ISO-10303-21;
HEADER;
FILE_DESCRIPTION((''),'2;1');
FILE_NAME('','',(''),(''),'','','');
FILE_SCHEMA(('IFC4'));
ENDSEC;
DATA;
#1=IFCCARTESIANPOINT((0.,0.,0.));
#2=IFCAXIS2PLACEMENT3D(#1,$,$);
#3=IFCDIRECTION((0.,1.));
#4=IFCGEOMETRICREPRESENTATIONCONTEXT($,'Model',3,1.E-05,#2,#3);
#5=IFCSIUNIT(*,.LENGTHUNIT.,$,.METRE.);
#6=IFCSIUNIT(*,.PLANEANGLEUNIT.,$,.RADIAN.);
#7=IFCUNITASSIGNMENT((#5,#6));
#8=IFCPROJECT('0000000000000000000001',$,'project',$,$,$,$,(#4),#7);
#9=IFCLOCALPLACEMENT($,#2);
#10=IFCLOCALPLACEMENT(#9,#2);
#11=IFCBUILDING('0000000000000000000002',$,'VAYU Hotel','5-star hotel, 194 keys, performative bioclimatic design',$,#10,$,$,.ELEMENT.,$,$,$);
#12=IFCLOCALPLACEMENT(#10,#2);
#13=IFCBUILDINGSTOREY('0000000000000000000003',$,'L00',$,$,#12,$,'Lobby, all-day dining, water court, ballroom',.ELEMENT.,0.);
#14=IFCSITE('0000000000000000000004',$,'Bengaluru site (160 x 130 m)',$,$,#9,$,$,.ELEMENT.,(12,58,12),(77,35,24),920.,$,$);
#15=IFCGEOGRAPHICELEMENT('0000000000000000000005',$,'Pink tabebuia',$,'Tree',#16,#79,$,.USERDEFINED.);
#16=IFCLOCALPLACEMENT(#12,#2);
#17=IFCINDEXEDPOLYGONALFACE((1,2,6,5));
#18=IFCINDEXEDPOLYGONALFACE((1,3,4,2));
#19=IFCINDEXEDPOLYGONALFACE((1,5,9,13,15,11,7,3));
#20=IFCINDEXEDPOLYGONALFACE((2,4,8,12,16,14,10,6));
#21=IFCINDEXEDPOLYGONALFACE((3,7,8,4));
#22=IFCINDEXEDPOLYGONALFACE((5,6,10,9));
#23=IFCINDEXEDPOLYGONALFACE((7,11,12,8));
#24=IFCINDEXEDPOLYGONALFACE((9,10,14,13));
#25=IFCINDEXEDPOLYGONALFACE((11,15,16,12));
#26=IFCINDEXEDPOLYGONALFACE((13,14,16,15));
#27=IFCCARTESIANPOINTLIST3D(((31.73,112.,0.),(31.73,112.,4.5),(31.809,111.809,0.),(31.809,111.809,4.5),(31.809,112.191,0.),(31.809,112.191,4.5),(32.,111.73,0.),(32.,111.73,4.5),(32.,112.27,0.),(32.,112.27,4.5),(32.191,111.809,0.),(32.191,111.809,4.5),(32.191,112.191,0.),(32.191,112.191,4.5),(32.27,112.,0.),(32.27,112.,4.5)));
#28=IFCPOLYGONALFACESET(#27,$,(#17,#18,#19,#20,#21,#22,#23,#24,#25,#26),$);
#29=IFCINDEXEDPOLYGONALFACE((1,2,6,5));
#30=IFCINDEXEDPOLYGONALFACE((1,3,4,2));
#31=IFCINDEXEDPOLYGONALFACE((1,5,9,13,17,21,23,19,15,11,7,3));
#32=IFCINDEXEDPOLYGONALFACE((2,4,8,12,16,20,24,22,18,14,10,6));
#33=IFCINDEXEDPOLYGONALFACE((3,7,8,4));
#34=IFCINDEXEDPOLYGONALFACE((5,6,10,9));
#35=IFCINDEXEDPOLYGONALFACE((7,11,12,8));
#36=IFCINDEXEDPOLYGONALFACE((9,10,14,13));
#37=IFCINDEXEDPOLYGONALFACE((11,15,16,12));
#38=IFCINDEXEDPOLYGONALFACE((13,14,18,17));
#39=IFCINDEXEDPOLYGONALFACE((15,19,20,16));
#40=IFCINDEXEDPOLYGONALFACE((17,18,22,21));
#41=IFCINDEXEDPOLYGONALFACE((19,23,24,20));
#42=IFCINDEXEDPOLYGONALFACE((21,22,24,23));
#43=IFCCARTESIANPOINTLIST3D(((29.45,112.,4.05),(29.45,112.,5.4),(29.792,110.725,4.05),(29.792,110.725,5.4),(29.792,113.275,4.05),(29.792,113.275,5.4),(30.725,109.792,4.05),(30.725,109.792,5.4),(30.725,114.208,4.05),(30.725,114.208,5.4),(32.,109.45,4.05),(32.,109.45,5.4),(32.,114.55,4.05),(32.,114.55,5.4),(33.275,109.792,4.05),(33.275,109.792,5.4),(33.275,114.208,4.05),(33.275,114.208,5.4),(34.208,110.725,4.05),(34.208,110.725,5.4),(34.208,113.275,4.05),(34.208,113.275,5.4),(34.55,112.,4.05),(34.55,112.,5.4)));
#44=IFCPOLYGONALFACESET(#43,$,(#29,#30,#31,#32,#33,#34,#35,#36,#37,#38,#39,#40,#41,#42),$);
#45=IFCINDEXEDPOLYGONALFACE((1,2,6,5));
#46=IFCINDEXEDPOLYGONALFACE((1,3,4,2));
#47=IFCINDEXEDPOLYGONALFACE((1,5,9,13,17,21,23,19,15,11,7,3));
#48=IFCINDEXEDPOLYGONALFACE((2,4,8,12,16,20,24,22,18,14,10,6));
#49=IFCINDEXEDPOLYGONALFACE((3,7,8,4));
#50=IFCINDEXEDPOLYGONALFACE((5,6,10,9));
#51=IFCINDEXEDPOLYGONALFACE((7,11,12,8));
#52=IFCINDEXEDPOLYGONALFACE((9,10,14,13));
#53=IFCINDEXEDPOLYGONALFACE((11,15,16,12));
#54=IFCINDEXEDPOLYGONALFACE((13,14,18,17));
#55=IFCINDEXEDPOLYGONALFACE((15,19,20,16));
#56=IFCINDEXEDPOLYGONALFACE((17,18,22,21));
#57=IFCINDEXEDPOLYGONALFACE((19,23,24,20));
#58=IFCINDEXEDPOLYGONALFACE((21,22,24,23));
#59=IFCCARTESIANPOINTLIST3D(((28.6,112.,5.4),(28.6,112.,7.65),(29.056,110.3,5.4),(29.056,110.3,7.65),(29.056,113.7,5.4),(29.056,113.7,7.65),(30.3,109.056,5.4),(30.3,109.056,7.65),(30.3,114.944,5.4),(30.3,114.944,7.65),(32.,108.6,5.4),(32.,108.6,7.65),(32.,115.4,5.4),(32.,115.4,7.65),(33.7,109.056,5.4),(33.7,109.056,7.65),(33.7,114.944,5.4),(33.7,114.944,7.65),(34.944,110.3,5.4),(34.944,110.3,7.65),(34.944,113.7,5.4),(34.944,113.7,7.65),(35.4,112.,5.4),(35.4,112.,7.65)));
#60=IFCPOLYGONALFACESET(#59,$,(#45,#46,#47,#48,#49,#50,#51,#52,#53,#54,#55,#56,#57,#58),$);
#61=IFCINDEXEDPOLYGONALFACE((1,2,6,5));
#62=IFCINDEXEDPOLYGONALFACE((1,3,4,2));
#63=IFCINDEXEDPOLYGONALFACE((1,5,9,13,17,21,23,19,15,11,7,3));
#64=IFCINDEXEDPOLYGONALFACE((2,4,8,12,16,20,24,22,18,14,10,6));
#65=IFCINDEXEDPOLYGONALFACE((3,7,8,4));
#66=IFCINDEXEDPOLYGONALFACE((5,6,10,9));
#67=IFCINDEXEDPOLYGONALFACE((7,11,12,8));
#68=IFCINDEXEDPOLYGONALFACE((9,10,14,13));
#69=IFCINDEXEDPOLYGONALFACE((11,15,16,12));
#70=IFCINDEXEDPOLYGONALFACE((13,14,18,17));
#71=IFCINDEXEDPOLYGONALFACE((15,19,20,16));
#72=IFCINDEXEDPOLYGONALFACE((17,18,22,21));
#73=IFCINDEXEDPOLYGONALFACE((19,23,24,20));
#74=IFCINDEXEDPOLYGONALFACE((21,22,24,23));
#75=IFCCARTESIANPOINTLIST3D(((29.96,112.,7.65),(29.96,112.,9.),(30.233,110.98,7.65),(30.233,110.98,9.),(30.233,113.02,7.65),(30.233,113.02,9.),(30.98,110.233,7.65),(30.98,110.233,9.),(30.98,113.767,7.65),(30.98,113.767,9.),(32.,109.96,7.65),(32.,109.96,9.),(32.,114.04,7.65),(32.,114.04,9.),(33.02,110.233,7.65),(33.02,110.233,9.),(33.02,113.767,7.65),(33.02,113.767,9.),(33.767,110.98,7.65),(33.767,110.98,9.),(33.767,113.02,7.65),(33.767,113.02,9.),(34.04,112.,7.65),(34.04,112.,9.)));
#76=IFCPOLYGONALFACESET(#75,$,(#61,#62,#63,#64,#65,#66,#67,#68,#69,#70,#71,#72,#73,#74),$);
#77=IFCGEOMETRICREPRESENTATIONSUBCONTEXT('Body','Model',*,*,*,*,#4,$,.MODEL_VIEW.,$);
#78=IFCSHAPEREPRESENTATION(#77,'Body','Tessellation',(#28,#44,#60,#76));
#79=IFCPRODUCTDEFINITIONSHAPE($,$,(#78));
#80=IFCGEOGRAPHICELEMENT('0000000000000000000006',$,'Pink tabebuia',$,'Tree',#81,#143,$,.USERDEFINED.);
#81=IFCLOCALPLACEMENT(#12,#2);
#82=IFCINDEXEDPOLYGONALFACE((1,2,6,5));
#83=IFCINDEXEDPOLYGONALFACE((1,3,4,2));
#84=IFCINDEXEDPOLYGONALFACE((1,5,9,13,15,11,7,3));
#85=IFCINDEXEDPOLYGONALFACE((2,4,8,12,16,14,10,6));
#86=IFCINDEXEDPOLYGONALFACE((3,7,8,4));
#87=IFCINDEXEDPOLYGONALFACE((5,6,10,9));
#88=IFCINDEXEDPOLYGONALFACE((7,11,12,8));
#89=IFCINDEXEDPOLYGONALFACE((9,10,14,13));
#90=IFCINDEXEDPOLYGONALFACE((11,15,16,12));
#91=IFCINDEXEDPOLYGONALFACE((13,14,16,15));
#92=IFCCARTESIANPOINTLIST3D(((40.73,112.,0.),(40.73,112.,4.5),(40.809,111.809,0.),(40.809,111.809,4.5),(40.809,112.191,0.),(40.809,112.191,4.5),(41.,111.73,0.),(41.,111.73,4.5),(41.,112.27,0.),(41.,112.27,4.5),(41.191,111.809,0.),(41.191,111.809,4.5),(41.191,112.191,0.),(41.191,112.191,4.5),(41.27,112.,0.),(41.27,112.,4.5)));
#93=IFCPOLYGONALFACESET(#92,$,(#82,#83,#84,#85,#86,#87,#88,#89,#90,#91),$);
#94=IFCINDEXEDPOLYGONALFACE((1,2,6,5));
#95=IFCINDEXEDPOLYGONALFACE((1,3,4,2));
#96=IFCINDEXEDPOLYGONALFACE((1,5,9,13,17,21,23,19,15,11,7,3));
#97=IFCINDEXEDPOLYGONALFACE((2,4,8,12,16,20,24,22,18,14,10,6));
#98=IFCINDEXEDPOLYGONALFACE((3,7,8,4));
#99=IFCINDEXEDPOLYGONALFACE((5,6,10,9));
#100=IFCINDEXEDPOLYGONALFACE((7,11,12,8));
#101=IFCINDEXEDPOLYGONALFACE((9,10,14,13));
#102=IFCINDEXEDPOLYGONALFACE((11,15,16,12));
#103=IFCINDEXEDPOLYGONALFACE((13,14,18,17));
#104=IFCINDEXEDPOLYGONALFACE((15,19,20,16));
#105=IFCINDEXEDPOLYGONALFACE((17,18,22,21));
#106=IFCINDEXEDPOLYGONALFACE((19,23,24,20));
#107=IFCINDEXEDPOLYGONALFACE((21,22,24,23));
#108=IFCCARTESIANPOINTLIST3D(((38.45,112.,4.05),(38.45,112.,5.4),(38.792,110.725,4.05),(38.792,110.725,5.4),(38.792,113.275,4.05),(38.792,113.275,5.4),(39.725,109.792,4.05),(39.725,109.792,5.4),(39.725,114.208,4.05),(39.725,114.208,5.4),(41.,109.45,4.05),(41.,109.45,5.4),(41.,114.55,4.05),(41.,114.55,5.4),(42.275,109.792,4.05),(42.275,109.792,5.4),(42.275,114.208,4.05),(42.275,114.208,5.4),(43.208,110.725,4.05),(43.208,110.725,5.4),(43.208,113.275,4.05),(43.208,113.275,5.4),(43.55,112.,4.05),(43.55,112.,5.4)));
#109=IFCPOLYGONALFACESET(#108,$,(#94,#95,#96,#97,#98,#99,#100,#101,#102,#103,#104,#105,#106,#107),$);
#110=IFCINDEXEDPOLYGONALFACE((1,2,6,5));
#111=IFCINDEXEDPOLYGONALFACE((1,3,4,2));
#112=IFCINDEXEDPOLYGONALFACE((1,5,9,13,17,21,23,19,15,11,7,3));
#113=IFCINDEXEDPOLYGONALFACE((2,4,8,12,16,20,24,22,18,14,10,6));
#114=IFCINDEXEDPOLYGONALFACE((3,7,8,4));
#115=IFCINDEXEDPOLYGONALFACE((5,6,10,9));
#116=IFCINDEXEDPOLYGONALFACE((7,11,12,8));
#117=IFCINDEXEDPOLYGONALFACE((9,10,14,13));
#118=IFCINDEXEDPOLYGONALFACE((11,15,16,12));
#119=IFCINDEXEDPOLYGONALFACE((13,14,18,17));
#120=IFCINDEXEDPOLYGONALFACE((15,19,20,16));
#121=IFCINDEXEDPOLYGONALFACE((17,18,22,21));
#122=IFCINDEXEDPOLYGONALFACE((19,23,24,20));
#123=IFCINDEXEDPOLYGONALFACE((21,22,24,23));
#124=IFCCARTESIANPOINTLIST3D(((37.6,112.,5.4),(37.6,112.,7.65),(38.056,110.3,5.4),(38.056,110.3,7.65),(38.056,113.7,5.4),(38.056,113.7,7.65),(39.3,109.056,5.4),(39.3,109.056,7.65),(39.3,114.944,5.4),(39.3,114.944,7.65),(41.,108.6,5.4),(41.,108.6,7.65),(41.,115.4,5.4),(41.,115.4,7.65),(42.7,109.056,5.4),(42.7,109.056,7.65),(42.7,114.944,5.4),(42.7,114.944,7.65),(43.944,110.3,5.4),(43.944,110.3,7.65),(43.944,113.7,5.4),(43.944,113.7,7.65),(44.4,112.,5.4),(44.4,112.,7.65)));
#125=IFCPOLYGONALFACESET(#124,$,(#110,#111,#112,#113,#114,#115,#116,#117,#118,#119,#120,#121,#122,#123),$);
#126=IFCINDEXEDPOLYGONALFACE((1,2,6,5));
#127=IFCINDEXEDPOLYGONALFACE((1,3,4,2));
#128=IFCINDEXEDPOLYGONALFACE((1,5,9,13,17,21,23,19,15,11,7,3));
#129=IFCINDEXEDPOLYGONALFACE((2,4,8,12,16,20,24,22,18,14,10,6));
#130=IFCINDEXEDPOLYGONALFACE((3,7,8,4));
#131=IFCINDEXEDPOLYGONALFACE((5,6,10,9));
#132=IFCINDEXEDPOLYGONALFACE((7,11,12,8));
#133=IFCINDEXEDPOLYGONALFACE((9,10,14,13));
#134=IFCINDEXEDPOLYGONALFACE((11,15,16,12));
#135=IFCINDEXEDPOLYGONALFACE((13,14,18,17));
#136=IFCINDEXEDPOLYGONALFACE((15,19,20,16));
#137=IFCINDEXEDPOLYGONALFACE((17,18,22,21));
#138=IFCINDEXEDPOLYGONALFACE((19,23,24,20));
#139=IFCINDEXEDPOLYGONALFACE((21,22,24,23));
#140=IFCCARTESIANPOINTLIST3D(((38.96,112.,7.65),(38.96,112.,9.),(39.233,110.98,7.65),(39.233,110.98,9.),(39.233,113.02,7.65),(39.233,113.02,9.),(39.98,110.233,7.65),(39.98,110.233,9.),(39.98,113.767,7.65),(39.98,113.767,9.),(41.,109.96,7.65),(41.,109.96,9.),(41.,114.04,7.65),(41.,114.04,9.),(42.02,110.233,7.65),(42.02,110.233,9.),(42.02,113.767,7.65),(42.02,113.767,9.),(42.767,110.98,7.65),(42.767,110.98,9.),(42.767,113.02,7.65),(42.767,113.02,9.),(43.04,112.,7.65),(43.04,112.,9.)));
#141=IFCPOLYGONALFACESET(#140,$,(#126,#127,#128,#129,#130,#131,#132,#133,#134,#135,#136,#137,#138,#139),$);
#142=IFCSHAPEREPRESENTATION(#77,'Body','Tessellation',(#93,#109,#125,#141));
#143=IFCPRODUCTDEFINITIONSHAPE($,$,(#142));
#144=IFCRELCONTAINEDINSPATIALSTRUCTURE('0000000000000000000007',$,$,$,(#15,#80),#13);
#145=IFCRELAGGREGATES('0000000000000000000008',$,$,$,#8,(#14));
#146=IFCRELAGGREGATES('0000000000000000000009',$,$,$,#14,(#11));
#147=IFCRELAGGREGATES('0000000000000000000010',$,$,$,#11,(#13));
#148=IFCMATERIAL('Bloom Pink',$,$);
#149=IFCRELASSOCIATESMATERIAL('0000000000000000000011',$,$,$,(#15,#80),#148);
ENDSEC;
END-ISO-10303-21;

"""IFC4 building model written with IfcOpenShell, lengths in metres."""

from ifc_helpers import new_model, si_unit, direction, frame, origin, place, context, subcontext, project, spatial, polyline, outline, extrude, material, element, save


model = new_model("IFC4")

# Units and contexts
model_context = context("Model", 3, precision=1e-05, world=origin(), true_north=direction((0.0, 1.0)))
body_context = subcontext(model_context, "Body", "Model", "MODEL_VIEW")
ifc_project = project(units=[si_unit("LENGTHUNIT", "METRE"), si_unit("PLANEANGLEUNIT", "RADIAN")], contexts=[model_context])

# Site, building, storey
site_placement = place(None, origin())
site = spatial("IfcSite", under=ifc_project, at=site_placement, Name="Bengaluru site (160 x 130 m)", CompositionType="ELEMENT", RefLatitude=(12, 58, 12), RefLongitude=(77, 35, 24), RefElevation=920.0)
building_placement = place(site_placement, origin())
building = spatial("IfcBuilding", under=site, at=building_placement, Name="VAYU Hotel", Description="5-star hotel, 194 keys, performative bioclimatic design", CompositionType="ELEMENT")
storey_placement = place(building_placement, origin())
storey = spatial("IfcBuildingStorey", under=building, at=storey_placement, Name="L00", LongName="Lobby, all-day dining, water court, ballroom", CompositionType="ELEMENT", Elevation=0.0)

# Geographic elements
ifc_material_1 = material(Name="Bloom Pink")
geographic_element_1_placement = place(storey_placement, origin())
element("IfcGeographicElement", 1, at=geographic_element_1_placement, inside=storey, material=ifc_material_1, Name="Pink tabebuia", ObjectType="Tree", PredefinedType="USERDEFINED", context=body_context, shape_type="SweptSolid", body=[
    extrude(outline(polyline([(32.27, 112.0), (32.191, 112.191), (32.0, 112.27), (31.809, 112.191), (31.73, 112.0), (31.809, 111.809), (32.0, 111.73), (32.191, 111.809), (32.27, 112.0)])), origin(), (0.0, 0.0, 1.0), 4.5),
    extrude(outline(polyline([(34.55, 112.0), (34.208, 113.275), (33.275, 114.208), (32.0, 114.55), (30.725, 114.208), (29.792, 113.275), (29.45, 112.0), (29.792, 110.725), (30.725, 109.792), (32.0, 109.45), (33.275, 109.792), (34.208, 110.725), (34.55, 112.0)])), frame((0.0, 0.0, 4.05)), (0.0, 0.0, 1.0), 1.35),
    extrude(outline(polyline([(35.4, 112.0), (34.944, 113.7), (33.7, 114.944), (32.0, 115.4), (30.3, 114.944), (29.056, 113.7), (28.6, 112.0), (29.056, 110.3), (30.3, 109.056), (32.0, 108.6), (33.7, 109.056), (34.944, 110.3), (35.4, 112.0)])), frame((0.0, 0.0, 5.4)), (0.0, 0.0, 1.0), 2.25),
    extrude(outline(polyline([(34.04, 112.0), (33.767, 113.02), (33.02, 113.767), (32.0, 114.04), (30.98, 113.767), (30.233, 113.02), (29.96, 112.0), (30.233, 110.98), (30.98, 110.233), (32.0, 109.96), (33.02, 110.233), (33.767, 110.98), (34.04, 112.0)])), frame((0.0, 0.0, 7.65)), (0.0, 0.0, 1.0), 1.35),
])
geographic_element_2_placement = place(storey_placement, origin())
element("IfcGeographicElement", 2, at=geographic_element_2_placement, inside=storey, material=ifc_material_1, Name="Pink tabebuia", ObjectType="Tree", PredefinedType="USERDEFINED", context=body_context, shape_type="SweptSolid", body=[
    extrude(outline(polyline([(41.27, 112.0), (41.191, 112.191), (41.0, 112.27), (40.809, 112.191), (40.73, 112.0), (40.809, 111.809), (41.0, 111.73), (41.191, 111.809), (41.27, 112.0)])), origin(), (0.0, 0.0, 1.0), 4.5),
    extrude(outline(polyline([(43.55, 112.0), (43.208, 113.275), (42.275, 114.208), (41.0, 114.55), (39.725, 114.208), (38.792, 113.275), (38.45, 112.0), (38.792, 110.725), (39.725, 109.792), (41.0, 109.45), (42.275, 109.792), (43.208, 110.725), (43.55, 112.0)])), frame((0.0, 0.0, 4.05)), (0.0, 0.0, 1.0), 1.35),
    extrude(outline(polyline([(44.4, 112.0), (43.944, 113.7), (42.7, 114.944), (41.0, 115.4), (39.3, 114.944), (38.056, 113.7), (37.6, 112.0), (38.056, 110.3), (39.3, 109.056), (41.0, 108.6), (42.7, 109.056), (43.944, 110.3), (44.4, 112.0)])), frame((0.0, 0.0, 5.4)), (0.0, 0.0, 1.0), 2.25),
    extrude(outline(polyline([(43.04, 112.0), (42.767, 113.02), (42.02, 113.767), (41.0, 114.04), (39.98, 113.767), (39.233, 113.02), (38.96, 112.0), (39.233, 110.98), (39.98, 110.233), (41.0, 109.96), (42.02, 110.233), (42.767, 110.98), (43.04, 112.0)])), frame((0.0, 0.0, 7.65)), (0.0, 0.0, 1.0), 1.35),
])

save(model, "model.ifc")
